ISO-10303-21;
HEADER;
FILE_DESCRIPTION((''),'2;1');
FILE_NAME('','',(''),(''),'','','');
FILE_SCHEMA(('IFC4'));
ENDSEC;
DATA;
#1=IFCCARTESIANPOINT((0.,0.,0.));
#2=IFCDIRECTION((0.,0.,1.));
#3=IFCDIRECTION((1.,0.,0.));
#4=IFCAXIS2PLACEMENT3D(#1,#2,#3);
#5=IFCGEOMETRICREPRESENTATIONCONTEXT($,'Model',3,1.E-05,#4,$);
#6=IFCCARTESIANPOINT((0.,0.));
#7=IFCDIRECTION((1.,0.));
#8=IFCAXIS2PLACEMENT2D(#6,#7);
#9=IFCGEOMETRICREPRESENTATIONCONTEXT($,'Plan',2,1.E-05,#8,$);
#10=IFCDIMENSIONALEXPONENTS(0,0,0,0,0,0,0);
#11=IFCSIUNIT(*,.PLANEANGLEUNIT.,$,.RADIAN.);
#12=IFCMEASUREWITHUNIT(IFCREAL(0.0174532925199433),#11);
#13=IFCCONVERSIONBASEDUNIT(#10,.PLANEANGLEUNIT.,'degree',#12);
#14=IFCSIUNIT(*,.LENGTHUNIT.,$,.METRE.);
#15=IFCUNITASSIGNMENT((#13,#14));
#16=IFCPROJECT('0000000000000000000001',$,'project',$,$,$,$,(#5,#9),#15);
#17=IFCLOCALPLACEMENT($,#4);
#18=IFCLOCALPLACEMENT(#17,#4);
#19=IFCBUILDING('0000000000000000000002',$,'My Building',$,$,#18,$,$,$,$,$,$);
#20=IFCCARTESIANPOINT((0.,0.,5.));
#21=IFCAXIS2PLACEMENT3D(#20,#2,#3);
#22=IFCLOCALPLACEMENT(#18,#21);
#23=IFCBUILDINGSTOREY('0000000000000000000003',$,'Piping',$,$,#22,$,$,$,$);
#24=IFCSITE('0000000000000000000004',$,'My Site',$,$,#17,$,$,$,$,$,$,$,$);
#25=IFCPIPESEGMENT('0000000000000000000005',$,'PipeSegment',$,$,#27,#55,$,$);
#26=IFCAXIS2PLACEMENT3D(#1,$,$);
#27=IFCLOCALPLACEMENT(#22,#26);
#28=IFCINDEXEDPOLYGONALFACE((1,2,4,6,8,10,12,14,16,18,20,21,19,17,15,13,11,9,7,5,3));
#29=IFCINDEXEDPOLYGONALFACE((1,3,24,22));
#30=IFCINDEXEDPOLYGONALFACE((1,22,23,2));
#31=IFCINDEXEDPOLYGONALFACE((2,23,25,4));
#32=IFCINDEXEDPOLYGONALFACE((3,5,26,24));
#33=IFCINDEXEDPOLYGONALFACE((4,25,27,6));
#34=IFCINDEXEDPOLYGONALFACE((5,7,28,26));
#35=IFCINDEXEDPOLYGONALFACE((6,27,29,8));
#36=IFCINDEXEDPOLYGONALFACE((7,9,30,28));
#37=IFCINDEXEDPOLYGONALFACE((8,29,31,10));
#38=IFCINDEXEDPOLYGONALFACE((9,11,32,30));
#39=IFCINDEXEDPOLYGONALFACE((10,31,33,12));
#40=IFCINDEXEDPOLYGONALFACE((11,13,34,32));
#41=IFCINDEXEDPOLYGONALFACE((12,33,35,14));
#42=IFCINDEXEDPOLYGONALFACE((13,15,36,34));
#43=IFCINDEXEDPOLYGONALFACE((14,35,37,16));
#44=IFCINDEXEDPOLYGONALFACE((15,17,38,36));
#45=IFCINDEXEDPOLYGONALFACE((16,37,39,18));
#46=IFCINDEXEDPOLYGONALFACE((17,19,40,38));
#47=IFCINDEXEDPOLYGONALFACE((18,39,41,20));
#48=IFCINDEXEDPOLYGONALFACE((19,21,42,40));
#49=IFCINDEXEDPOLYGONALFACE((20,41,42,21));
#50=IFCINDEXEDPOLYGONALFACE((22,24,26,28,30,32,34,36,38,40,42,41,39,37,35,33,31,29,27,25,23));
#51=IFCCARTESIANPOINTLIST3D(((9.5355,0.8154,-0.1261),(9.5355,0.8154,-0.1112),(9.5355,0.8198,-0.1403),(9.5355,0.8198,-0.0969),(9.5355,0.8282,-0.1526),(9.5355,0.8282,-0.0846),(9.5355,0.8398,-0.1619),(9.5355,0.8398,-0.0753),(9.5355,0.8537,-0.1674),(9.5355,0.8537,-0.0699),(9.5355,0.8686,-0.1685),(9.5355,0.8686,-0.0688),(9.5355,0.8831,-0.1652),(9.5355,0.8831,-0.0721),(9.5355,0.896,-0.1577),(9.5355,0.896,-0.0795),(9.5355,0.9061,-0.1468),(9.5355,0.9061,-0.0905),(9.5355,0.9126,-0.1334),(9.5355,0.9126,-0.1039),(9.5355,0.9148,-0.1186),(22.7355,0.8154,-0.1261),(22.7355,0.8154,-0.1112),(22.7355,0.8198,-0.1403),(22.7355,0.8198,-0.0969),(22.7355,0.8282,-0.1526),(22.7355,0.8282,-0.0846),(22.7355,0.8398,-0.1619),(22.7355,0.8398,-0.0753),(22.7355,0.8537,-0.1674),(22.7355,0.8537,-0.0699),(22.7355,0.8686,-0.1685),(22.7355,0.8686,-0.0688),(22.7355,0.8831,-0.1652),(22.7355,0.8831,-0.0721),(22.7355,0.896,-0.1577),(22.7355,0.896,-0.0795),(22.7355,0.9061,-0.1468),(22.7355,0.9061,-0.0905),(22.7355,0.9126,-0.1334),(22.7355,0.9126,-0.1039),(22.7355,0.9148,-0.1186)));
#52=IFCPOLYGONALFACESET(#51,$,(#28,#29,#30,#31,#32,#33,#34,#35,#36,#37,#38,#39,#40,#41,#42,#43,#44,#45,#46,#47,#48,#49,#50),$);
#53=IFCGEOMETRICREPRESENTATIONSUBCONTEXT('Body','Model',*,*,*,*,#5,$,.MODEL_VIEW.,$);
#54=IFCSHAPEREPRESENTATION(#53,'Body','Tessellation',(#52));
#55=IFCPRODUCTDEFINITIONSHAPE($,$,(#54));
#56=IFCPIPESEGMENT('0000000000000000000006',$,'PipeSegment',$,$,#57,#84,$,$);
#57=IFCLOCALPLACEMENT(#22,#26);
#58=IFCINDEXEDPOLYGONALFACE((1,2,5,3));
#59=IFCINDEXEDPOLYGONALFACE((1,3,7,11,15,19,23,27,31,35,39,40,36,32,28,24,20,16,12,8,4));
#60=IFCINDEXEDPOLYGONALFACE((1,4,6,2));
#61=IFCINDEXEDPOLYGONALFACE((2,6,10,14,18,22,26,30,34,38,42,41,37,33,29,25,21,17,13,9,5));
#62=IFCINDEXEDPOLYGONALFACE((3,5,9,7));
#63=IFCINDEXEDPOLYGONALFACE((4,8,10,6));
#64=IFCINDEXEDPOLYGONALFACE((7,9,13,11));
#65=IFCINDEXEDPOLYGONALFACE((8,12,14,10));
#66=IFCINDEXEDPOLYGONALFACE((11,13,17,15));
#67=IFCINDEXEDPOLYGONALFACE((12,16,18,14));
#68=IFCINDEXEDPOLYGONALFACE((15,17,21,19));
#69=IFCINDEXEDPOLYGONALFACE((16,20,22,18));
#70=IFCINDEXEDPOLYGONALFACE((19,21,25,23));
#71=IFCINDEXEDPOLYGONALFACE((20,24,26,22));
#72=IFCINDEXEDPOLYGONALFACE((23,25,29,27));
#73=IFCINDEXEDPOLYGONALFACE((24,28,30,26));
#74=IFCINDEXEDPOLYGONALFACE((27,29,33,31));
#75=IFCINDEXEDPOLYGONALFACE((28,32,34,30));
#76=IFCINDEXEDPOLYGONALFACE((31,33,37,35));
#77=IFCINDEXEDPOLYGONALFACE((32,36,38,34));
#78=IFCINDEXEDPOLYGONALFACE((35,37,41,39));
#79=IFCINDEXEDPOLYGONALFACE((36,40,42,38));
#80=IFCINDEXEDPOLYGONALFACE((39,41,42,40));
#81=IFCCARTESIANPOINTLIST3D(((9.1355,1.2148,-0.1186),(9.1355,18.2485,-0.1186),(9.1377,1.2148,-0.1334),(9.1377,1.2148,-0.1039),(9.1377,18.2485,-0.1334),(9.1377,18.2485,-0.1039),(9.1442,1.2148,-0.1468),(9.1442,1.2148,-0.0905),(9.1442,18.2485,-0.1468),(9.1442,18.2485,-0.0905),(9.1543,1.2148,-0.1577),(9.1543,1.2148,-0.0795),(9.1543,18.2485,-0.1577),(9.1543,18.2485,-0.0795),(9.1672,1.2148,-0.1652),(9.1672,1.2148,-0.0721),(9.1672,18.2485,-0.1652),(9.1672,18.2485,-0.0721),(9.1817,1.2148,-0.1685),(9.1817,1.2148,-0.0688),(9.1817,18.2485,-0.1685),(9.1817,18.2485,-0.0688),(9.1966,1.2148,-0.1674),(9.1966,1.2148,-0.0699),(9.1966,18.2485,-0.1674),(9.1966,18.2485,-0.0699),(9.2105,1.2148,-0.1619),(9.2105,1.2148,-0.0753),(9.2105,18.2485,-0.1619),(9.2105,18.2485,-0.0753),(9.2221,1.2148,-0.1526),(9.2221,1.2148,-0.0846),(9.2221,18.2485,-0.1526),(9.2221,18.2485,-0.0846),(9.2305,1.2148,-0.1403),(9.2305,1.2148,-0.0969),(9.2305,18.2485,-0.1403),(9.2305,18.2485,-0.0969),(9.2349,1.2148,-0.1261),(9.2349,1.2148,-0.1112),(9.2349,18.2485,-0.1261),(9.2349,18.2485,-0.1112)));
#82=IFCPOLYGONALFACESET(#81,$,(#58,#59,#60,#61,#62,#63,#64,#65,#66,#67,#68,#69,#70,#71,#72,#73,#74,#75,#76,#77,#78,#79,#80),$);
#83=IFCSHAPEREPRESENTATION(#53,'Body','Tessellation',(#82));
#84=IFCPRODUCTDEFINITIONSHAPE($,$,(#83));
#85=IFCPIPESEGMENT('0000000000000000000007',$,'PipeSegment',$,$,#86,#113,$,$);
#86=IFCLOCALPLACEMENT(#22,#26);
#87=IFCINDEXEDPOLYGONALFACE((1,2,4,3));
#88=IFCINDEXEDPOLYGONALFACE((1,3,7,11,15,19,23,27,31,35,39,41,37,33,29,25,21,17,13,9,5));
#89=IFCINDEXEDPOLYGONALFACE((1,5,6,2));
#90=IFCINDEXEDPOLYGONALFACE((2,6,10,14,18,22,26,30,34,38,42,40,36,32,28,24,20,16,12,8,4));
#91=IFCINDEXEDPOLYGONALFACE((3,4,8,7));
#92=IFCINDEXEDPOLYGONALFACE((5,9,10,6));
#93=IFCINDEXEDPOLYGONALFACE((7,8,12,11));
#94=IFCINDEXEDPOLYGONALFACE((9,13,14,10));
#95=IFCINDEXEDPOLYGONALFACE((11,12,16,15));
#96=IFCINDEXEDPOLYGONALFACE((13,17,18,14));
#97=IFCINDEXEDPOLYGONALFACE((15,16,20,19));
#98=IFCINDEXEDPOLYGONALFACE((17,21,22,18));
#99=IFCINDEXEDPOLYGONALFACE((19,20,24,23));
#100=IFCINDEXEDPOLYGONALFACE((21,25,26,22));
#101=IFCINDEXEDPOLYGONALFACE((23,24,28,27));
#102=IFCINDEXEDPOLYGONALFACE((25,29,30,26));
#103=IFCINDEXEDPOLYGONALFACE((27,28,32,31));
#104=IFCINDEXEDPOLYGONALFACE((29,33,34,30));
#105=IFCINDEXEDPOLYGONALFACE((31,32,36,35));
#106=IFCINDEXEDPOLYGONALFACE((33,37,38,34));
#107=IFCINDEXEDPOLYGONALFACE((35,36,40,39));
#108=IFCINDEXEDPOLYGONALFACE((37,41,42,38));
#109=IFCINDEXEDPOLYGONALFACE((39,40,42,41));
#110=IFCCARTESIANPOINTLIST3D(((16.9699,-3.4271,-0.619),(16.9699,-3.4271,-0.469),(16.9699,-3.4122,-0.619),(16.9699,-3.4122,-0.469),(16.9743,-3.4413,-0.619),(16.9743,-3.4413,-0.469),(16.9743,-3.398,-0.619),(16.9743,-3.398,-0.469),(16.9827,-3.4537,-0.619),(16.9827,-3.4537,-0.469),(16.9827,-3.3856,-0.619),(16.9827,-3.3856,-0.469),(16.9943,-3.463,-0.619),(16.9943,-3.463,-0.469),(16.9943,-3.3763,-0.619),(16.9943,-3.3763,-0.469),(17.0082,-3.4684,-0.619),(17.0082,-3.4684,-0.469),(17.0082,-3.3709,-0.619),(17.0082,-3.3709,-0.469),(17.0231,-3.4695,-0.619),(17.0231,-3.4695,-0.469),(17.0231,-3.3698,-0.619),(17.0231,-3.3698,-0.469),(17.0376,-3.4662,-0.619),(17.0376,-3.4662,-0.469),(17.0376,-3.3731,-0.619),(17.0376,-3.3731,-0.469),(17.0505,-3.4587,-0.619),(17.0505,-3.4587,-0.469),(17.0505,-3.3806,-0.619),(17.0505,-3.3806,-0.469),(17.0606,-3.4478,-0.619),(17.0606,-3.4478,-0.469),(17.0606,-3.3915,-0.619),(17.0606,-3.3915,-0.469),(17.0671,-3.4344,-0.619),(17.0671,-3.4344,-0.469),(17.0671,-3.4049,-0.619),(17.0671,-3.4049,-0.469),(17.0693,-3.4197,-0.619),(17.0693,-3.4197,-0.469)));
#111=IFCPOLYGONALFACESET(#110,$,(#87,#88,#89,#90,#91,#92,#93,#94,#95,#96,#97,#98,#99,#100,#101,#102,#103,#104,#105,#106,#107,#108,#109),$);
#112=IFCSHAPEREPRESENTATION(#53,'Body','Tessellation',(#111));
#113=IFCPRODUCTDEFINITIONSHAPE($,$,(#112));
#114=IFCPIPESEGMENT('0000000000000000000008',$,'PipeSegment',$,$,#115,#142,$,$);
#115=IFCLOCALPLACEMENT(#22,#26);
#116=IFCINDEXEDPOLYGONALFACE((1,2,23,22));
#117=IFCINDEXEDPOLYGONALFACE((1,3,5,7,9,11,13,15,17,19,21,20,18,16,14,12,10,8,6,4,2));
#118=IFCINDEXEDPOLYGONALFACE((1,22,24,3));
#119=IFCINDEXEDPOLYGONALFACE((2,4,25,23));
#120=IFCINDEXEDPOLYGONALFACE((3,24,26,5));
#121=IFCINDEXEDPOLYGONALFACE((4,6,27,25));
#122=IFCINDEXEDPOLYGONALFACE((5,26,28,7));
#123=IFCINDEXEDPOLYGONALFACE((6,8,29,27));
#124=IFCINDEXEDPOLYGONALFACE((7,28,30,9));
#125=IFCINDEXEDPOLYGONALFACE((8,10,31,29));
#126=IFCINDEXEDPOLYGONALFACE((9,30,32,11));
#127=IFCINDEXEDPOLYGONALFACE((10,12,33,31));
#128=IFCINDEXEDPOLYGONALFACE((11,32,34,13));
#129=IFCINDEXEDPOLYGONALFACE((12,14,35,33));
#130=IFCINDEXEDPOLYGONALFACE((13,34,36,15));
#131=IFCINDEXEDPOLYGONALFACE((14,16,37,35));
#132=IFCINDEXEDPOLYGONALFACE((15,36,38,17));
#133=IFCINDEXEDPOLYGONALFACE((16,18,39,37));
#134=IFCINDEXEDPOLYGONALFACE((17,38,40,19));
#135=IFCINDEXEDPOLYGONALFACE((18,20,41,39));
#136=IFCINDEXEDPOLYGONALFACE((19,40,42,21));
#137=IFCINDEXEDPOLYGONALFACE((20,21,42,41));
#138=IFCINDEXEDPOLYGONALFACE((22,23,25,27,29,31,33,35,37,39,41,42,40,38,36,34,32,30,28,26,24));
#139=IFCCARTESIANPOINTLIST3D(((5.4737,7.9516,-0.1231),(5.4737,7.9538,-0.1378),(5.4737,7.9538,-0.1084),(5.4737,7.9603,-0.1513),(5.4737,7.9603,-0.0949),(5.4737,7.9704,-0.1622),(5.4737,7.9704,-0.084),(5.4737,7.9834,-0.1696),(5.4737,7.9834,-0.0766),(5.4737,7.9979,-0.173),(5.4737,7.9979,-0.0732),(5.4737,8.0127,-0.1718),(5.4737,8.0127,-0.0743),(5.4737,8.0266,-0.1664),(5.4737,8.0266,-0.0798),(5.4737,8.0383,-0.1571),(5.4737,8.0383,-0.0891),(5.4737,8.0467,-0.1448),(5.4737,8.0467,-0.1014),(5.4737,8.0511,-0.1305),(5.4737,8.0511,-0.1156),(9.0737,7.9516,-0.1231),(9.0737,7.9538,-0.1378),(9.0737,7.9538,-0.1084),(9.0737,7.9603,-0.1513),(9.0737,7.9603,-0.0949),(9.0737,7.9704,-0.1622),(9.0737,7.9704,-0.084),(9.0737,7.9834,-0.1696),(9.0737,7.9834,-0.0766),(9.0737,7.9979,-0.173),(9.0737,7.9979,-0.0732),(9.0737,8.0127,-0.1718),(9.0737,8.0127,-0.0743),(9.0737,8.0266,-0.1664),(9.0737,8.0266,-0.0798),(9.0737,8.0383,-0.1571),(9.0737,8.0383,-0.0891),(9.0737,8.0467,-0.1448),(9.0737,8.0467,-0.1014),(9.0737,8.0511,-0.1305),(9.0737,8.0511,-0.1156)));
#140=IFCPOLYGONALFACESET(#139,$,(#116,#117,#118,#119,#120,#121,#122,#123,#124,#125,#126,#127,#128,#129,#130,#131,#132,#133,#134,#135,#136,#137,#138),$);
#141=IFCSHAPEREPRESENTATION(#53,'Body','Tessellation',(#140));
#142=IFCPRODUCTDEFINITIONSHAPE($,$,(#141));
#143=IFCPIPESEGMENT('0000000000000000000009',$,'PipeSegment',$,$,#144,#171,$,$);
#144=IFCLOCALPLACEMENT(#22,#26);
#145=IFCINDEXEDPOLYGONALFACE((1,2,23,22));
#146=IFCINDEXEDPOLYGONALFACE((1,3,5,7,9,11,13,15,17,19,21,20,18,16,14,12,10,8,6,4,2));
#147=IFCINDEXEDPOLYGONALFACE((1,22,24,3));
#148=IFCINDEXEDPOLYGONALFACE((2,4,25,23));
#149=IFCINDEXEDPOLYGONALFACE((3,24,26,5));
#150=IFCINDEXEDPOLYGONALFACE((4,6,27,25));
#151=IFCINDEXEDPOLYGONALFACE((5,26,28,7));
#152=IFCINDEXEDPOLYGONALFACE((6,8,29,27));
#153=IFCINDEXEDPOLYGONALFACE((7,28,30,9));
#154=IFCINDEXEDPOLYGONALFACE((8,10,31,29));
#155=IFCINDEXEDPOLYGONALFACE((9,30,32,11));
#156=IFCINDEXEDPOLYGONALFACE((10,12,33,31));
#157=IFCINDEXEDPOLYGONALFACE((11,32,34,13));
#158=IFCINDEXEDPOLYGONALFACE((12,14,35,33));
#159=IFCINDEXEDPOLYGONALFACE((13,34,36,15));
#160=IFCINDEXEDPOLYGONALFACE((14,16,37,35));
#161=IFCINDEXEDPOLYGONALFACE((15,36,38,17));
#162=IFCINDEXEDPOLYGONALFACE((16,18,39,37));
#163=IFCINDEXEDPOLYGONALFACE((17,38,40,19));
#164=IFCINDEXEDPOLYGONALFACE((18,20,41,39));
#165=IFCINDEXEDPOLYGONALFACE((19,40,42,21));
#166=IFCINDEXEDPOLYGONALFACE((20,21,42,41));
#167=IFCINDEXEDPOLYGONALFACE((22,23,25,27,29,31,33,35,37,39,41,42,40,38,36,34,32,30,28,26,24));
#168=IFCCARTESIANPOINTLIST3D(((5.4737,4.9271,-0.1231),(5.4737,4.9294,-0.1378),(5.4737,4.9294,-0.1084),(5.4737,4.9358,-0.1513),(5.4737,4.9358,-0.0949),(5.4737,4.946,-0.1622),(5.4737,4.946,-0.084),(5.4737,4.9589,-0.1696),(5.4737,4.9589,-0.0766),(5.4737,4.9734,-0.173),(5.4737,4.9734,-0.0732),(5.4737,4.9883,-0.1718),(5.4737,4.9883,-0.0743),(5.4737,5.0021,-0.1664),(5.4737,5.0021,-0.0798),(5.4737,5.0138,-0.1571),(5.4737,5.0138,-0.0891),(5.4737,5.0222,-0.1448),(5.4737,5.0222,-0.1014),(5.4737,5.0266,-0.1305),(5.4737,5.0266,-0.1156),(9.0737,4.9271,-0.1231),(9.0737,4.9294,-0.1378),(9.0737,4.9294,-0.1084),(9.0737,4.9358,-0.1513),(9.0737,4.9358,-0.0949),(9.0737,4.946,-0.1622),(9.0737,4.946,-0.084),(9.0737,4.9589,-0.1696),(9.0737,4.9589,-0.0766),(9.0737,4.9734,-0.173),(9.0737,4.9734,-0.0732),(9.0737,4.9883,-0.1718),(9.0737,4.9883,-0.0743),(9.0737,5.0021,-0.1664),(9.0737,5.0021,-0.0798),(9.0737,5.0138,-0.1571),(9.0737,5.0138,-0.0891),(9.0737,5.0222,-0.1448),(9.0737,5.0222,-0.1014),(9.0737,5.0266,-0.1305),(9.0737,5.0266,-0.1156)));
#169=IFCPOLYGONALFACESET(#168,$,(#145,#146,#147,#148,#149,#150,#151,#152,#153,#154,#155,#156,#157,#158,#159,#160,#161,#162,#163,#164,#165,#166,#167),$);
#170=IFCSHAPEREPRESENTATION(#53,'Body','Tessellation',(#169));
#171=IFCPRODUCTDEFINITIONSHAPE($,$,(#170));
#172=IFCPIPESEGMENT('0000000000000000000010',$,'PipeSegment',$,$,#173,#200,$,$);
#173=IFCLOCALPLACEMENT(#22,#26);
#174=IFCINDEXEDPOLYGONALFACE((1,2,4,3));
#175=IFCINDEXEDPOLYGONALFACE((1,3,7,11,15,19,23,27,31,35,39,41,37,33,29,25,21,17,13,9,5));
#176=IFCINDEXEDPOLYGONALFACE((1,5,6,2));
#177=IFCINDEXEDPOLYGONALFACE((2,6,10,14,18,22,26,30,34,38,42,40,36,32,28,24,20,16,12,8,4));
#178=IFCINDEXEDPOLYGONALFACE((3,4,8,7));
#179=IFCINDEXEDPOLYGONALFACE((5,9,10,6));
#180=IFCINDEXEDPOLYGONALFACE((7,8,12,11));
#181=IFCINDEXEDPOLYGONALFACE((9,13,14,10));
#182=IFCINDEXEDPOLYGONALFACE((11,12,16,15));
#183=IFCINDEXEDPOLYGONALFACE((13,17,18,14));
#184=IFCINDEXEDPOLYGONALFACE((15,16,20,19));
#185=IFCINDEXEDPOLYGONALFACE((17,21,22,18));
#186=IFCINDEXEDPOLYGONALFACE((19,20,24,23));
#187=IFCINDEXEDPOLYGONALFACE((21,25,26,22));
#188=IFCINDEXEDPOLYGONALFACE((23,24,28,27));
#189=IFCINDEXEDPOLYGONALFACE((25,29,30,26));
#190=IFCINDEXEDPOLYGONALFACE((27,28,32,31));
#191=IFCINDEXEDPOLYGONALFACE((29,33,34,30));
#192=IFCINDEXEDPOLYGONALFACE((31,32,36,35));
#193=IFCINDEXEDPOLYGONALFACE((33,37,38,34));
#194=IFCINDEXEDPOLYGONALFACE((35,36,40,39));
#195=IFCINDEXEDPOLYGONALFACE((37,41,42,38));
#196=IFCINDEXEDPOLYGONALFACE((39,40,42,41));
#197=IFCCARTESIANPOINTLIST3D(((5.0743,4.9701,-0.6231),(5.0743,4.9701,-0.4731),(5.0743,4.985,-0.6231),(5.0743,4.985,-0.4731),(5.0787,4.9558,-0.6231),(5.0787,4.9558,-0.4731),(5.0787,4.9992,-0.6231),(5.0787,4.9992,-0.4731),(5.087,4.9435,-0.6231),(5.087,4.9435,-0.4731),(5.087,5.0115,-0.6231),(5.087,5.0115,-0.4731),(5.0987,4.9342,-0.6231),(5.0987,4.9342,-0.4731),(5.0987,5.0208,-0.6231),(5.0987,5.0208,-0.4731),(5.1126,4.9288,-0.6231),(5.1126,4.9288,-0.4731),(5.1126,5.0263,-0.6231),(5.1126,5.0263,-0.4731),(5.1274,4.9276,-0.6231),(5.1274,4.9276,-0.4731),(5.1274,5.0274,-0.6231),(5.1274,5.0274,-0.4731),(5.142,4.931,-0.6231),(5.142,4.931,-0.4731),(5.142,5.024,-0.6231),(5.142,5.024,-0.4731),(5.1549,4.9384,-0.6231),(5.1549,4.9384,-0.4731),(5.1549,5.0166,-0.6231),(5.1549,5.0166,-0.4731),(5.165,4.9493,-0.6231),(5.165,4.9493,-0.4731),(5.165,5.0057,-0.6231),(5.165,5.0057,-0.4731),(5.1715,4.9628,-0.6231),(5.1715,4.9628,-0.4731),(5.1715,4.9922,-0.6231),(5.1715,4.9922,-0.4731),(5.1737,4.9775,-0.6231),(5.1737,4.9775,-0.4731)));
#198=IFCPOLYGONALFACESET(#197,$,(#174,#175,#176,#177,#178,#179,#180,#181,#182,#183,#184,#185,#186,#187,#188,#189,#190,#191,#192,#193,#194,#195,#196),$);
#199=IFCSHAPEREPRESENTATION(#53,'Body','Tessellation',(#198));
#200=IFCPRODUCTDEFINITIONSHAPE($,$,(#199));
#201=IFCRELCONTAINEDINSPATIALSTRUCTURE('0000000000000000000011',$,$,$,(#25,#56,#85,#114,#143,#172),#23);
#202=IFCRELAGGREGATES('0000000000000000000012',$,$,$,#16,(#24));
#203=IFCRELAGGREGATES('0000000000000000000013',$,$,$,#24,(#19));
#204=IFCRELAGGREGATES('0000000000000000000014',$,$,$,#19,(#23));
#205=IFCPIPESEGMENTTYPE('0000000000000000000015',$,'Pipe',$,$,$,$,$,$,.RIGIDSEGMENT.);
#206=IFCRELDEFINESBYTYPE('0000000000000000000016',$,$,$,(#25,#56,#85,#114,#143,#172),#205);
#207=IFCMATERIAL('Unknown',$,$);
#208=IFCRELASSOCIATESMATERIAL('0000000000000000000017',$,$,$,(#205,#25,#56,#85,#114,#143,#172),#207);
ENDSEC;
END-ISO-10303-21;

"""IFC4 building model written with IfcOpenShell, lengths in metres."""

from ifc_helpers import new_model, entity, si_unit, converted_unit, frame, origin_with_axes, origin_2d_with_axis, place, context, subcontext, project, spatial, circle, extrude, material, material_profile, profile_set, profile_usage, type_object, element, save


model = new_model("IFC4")

# Units and contexts
model_context = context("Model", 3, precision=1e-05, world=origin_with_axes())
plan_context = context("Plan", 2, precision=1e-05, world=origin_2d_with_axis())
body_context = subcontext(model_context, "Body", "Model", "MODEL_VIEW")
ifc_project = project(units=[converted_unit("PLANEANGLEUNIT", "degree", entity("IfcReal", 0.0174532925199433), si_unit("PLANEANGLEUNIT", "RADIAN"), dimensions=[0, 0, 0, 0, 0, 0, 0]), si_unit("LENGTHUNIT", "METRE")], contexts=[model_context, plan_context])

# Site, building, storey
site_placement = place(None, origin_with_axes())
site = spatial("IfcSite", under=ifc_project, at=site_placement, Name="My Site")
building_placement = place(site_placement, origin_with_axes())
building = spatial("IfcBuilding", under=site, at=building_placement, Name="My Building")
storey_placement = place(building_placement, frame((0.0, 0.0, 5.0), z_axis=(0.0, 0.0, 1.0), x_axis=(1.0, 0.0, 0.0)))
storey = spatial("IfcBuildingStorey", under=building, at=storey_placement, Name="Piping")

# Pipe segments
ifc_material = material(Name="Unknown")
ifc_material_profile_1 = material_profile(ifc_material, circle(Radius=0.05))
ifc_profile_set_1 = profile_set([ifc_material_profile_1])
ifc_profile_usage_1 = profile_usage(ifc_profile_set_1, cardinal=5)
pipe_segment_type = type_object("IfcPipeSegmentType", Name="Pipe", PredefinedType="RIGIDSEGMENT", material=ifc_profile_set_1)
pipe_segment_1_placement = place(storey_placement, frame((9.5355, 0.8648, -0.1186), z_axis=(1.0, 0.0, 0.0), x_axis=(0.0, 1.0, 0.0)))
element("IfcPipeSegment", 1, at=pipe_segment_1_placement, inside=storey, type_object=pipe_segment_type, material=ifc_profile_usage_1, Name="PipeSegment", context=body_context, shape_type="SweptSolid", body=[
    extrude(circle(Radius=0.05), origin_with_axes(), (0.0, 0.0, 1.0), 13.2),
])
ifc_profile_usage_2 = profile_usage(ifc_profile_set_1, cardinal=5)
pipe_segment_2_placement = place(storey_placement, frame((9.1855, 1.2148, -0.1186), z_axis=(0.0, 1.0, 0.0), x_axis=(-1.0, 0.0, 0.0)))
element("IfcPipeSegment", 2, at=pipe_segment_2_placement, inside=storey, type_object=pipe_segment_type, material=ifc_profile_usage_2, Name="PipeSegment", context=body_context, shape_type="SweptSolid", body=[
    extrude(circle(Radius=0.05), origin_with_axes(), (0.0, 0.0, 1.0), 17.0337),
])
ifc_profile_usage_3 = profile_usage(ifc_profile_set_1, cardinal=5)
pipe_segment_3_placement = place(storey_placement, frame((17.0193, -3.4197, -0.469), z_axis=(0.0, 0.0, -1.0), x_axis=(1.0, -0.000053, 0.0)))
element("IfcPipeSegment", 3, at=pipe_segment_3_placement, inside=storey, type_object=pipe_segment_type, material=ifc_profile_usage_3, Name="PipeSegment", context=body_context, shape_type="SweptSolid", body=[
    extrude(circle(Radius=0.05), origin_with_axes(), (0.0, 0.0, 1.0), 0.15),
])
ifc_profile_usage_4 = profile_usage(ifc_profile_set_1, cardinal=5)
pipe_segment_4_placement = place(storey_placement, frame((9.0737, 8.0016, -0.1231), z_axis=(-1.0, 0.0, 0.0), x_axis=(0.0, -1.0, 0.0)))
element("IfcPipeSegment", 4, at=pipe_segment_4_placement, inside=storey, type_object=pipe_segment_type, material=ifc_profile_usage_4, Name="PipeSegment", context=body_context, shape_type="SweptSolid", body=[
    extrude(circle(Radius=0.05), origin_with_axes(), (0.0, 0.0, 1.0), 3.6),
])
ifc_profile_usage_5 = profile_usage(ifc_profile_set_1, cardinal=5)
pipe_segment_5_placement = place(storey_placement, frame((9.0737, 4.9771, -0.1231), z_axis=(-1.0, 0.0, 0.0), x_axis=(0.0, -1.0, 0.0)))
element("IfcPipeSegment", 5, at=pipe_segment_5_placement, inside=storey, type_object=pipe_segment_type, material=ifc_profile_usage_5, Name="PipeSegment", context=body_context, shape_type="SweptSolid", body=[
    extrude(circle(Radius=0.05), origin_with_axes(), (0.0, 0.0, 1.0), 3.6),
])
ifc_profile_usage_6 = profile_usage(ifc_profile_set_1, cardinal=5)
pipe_segment_6_placement = place(storey_placement, frame((5.1237, 4.9775, -0.4731), z_axis=(0.0, 0.0, -1.0), x_axis=(1.0, 0.0, 0.0)))
element("IfcPipeSegment", 6, at=pipe_segment_6_placement, inside=storey, type_object=pipe_segment_type, material=ifc_profile_usage_6, Name="PipeSegment", context=body_context, shape_type="SweptSolid", body=[
    extrude(circle(Radius=0.05), origin_with_axes(), (0.0, 0.0, 1.0), 0.15),
])

save(model, "model.ifc")
